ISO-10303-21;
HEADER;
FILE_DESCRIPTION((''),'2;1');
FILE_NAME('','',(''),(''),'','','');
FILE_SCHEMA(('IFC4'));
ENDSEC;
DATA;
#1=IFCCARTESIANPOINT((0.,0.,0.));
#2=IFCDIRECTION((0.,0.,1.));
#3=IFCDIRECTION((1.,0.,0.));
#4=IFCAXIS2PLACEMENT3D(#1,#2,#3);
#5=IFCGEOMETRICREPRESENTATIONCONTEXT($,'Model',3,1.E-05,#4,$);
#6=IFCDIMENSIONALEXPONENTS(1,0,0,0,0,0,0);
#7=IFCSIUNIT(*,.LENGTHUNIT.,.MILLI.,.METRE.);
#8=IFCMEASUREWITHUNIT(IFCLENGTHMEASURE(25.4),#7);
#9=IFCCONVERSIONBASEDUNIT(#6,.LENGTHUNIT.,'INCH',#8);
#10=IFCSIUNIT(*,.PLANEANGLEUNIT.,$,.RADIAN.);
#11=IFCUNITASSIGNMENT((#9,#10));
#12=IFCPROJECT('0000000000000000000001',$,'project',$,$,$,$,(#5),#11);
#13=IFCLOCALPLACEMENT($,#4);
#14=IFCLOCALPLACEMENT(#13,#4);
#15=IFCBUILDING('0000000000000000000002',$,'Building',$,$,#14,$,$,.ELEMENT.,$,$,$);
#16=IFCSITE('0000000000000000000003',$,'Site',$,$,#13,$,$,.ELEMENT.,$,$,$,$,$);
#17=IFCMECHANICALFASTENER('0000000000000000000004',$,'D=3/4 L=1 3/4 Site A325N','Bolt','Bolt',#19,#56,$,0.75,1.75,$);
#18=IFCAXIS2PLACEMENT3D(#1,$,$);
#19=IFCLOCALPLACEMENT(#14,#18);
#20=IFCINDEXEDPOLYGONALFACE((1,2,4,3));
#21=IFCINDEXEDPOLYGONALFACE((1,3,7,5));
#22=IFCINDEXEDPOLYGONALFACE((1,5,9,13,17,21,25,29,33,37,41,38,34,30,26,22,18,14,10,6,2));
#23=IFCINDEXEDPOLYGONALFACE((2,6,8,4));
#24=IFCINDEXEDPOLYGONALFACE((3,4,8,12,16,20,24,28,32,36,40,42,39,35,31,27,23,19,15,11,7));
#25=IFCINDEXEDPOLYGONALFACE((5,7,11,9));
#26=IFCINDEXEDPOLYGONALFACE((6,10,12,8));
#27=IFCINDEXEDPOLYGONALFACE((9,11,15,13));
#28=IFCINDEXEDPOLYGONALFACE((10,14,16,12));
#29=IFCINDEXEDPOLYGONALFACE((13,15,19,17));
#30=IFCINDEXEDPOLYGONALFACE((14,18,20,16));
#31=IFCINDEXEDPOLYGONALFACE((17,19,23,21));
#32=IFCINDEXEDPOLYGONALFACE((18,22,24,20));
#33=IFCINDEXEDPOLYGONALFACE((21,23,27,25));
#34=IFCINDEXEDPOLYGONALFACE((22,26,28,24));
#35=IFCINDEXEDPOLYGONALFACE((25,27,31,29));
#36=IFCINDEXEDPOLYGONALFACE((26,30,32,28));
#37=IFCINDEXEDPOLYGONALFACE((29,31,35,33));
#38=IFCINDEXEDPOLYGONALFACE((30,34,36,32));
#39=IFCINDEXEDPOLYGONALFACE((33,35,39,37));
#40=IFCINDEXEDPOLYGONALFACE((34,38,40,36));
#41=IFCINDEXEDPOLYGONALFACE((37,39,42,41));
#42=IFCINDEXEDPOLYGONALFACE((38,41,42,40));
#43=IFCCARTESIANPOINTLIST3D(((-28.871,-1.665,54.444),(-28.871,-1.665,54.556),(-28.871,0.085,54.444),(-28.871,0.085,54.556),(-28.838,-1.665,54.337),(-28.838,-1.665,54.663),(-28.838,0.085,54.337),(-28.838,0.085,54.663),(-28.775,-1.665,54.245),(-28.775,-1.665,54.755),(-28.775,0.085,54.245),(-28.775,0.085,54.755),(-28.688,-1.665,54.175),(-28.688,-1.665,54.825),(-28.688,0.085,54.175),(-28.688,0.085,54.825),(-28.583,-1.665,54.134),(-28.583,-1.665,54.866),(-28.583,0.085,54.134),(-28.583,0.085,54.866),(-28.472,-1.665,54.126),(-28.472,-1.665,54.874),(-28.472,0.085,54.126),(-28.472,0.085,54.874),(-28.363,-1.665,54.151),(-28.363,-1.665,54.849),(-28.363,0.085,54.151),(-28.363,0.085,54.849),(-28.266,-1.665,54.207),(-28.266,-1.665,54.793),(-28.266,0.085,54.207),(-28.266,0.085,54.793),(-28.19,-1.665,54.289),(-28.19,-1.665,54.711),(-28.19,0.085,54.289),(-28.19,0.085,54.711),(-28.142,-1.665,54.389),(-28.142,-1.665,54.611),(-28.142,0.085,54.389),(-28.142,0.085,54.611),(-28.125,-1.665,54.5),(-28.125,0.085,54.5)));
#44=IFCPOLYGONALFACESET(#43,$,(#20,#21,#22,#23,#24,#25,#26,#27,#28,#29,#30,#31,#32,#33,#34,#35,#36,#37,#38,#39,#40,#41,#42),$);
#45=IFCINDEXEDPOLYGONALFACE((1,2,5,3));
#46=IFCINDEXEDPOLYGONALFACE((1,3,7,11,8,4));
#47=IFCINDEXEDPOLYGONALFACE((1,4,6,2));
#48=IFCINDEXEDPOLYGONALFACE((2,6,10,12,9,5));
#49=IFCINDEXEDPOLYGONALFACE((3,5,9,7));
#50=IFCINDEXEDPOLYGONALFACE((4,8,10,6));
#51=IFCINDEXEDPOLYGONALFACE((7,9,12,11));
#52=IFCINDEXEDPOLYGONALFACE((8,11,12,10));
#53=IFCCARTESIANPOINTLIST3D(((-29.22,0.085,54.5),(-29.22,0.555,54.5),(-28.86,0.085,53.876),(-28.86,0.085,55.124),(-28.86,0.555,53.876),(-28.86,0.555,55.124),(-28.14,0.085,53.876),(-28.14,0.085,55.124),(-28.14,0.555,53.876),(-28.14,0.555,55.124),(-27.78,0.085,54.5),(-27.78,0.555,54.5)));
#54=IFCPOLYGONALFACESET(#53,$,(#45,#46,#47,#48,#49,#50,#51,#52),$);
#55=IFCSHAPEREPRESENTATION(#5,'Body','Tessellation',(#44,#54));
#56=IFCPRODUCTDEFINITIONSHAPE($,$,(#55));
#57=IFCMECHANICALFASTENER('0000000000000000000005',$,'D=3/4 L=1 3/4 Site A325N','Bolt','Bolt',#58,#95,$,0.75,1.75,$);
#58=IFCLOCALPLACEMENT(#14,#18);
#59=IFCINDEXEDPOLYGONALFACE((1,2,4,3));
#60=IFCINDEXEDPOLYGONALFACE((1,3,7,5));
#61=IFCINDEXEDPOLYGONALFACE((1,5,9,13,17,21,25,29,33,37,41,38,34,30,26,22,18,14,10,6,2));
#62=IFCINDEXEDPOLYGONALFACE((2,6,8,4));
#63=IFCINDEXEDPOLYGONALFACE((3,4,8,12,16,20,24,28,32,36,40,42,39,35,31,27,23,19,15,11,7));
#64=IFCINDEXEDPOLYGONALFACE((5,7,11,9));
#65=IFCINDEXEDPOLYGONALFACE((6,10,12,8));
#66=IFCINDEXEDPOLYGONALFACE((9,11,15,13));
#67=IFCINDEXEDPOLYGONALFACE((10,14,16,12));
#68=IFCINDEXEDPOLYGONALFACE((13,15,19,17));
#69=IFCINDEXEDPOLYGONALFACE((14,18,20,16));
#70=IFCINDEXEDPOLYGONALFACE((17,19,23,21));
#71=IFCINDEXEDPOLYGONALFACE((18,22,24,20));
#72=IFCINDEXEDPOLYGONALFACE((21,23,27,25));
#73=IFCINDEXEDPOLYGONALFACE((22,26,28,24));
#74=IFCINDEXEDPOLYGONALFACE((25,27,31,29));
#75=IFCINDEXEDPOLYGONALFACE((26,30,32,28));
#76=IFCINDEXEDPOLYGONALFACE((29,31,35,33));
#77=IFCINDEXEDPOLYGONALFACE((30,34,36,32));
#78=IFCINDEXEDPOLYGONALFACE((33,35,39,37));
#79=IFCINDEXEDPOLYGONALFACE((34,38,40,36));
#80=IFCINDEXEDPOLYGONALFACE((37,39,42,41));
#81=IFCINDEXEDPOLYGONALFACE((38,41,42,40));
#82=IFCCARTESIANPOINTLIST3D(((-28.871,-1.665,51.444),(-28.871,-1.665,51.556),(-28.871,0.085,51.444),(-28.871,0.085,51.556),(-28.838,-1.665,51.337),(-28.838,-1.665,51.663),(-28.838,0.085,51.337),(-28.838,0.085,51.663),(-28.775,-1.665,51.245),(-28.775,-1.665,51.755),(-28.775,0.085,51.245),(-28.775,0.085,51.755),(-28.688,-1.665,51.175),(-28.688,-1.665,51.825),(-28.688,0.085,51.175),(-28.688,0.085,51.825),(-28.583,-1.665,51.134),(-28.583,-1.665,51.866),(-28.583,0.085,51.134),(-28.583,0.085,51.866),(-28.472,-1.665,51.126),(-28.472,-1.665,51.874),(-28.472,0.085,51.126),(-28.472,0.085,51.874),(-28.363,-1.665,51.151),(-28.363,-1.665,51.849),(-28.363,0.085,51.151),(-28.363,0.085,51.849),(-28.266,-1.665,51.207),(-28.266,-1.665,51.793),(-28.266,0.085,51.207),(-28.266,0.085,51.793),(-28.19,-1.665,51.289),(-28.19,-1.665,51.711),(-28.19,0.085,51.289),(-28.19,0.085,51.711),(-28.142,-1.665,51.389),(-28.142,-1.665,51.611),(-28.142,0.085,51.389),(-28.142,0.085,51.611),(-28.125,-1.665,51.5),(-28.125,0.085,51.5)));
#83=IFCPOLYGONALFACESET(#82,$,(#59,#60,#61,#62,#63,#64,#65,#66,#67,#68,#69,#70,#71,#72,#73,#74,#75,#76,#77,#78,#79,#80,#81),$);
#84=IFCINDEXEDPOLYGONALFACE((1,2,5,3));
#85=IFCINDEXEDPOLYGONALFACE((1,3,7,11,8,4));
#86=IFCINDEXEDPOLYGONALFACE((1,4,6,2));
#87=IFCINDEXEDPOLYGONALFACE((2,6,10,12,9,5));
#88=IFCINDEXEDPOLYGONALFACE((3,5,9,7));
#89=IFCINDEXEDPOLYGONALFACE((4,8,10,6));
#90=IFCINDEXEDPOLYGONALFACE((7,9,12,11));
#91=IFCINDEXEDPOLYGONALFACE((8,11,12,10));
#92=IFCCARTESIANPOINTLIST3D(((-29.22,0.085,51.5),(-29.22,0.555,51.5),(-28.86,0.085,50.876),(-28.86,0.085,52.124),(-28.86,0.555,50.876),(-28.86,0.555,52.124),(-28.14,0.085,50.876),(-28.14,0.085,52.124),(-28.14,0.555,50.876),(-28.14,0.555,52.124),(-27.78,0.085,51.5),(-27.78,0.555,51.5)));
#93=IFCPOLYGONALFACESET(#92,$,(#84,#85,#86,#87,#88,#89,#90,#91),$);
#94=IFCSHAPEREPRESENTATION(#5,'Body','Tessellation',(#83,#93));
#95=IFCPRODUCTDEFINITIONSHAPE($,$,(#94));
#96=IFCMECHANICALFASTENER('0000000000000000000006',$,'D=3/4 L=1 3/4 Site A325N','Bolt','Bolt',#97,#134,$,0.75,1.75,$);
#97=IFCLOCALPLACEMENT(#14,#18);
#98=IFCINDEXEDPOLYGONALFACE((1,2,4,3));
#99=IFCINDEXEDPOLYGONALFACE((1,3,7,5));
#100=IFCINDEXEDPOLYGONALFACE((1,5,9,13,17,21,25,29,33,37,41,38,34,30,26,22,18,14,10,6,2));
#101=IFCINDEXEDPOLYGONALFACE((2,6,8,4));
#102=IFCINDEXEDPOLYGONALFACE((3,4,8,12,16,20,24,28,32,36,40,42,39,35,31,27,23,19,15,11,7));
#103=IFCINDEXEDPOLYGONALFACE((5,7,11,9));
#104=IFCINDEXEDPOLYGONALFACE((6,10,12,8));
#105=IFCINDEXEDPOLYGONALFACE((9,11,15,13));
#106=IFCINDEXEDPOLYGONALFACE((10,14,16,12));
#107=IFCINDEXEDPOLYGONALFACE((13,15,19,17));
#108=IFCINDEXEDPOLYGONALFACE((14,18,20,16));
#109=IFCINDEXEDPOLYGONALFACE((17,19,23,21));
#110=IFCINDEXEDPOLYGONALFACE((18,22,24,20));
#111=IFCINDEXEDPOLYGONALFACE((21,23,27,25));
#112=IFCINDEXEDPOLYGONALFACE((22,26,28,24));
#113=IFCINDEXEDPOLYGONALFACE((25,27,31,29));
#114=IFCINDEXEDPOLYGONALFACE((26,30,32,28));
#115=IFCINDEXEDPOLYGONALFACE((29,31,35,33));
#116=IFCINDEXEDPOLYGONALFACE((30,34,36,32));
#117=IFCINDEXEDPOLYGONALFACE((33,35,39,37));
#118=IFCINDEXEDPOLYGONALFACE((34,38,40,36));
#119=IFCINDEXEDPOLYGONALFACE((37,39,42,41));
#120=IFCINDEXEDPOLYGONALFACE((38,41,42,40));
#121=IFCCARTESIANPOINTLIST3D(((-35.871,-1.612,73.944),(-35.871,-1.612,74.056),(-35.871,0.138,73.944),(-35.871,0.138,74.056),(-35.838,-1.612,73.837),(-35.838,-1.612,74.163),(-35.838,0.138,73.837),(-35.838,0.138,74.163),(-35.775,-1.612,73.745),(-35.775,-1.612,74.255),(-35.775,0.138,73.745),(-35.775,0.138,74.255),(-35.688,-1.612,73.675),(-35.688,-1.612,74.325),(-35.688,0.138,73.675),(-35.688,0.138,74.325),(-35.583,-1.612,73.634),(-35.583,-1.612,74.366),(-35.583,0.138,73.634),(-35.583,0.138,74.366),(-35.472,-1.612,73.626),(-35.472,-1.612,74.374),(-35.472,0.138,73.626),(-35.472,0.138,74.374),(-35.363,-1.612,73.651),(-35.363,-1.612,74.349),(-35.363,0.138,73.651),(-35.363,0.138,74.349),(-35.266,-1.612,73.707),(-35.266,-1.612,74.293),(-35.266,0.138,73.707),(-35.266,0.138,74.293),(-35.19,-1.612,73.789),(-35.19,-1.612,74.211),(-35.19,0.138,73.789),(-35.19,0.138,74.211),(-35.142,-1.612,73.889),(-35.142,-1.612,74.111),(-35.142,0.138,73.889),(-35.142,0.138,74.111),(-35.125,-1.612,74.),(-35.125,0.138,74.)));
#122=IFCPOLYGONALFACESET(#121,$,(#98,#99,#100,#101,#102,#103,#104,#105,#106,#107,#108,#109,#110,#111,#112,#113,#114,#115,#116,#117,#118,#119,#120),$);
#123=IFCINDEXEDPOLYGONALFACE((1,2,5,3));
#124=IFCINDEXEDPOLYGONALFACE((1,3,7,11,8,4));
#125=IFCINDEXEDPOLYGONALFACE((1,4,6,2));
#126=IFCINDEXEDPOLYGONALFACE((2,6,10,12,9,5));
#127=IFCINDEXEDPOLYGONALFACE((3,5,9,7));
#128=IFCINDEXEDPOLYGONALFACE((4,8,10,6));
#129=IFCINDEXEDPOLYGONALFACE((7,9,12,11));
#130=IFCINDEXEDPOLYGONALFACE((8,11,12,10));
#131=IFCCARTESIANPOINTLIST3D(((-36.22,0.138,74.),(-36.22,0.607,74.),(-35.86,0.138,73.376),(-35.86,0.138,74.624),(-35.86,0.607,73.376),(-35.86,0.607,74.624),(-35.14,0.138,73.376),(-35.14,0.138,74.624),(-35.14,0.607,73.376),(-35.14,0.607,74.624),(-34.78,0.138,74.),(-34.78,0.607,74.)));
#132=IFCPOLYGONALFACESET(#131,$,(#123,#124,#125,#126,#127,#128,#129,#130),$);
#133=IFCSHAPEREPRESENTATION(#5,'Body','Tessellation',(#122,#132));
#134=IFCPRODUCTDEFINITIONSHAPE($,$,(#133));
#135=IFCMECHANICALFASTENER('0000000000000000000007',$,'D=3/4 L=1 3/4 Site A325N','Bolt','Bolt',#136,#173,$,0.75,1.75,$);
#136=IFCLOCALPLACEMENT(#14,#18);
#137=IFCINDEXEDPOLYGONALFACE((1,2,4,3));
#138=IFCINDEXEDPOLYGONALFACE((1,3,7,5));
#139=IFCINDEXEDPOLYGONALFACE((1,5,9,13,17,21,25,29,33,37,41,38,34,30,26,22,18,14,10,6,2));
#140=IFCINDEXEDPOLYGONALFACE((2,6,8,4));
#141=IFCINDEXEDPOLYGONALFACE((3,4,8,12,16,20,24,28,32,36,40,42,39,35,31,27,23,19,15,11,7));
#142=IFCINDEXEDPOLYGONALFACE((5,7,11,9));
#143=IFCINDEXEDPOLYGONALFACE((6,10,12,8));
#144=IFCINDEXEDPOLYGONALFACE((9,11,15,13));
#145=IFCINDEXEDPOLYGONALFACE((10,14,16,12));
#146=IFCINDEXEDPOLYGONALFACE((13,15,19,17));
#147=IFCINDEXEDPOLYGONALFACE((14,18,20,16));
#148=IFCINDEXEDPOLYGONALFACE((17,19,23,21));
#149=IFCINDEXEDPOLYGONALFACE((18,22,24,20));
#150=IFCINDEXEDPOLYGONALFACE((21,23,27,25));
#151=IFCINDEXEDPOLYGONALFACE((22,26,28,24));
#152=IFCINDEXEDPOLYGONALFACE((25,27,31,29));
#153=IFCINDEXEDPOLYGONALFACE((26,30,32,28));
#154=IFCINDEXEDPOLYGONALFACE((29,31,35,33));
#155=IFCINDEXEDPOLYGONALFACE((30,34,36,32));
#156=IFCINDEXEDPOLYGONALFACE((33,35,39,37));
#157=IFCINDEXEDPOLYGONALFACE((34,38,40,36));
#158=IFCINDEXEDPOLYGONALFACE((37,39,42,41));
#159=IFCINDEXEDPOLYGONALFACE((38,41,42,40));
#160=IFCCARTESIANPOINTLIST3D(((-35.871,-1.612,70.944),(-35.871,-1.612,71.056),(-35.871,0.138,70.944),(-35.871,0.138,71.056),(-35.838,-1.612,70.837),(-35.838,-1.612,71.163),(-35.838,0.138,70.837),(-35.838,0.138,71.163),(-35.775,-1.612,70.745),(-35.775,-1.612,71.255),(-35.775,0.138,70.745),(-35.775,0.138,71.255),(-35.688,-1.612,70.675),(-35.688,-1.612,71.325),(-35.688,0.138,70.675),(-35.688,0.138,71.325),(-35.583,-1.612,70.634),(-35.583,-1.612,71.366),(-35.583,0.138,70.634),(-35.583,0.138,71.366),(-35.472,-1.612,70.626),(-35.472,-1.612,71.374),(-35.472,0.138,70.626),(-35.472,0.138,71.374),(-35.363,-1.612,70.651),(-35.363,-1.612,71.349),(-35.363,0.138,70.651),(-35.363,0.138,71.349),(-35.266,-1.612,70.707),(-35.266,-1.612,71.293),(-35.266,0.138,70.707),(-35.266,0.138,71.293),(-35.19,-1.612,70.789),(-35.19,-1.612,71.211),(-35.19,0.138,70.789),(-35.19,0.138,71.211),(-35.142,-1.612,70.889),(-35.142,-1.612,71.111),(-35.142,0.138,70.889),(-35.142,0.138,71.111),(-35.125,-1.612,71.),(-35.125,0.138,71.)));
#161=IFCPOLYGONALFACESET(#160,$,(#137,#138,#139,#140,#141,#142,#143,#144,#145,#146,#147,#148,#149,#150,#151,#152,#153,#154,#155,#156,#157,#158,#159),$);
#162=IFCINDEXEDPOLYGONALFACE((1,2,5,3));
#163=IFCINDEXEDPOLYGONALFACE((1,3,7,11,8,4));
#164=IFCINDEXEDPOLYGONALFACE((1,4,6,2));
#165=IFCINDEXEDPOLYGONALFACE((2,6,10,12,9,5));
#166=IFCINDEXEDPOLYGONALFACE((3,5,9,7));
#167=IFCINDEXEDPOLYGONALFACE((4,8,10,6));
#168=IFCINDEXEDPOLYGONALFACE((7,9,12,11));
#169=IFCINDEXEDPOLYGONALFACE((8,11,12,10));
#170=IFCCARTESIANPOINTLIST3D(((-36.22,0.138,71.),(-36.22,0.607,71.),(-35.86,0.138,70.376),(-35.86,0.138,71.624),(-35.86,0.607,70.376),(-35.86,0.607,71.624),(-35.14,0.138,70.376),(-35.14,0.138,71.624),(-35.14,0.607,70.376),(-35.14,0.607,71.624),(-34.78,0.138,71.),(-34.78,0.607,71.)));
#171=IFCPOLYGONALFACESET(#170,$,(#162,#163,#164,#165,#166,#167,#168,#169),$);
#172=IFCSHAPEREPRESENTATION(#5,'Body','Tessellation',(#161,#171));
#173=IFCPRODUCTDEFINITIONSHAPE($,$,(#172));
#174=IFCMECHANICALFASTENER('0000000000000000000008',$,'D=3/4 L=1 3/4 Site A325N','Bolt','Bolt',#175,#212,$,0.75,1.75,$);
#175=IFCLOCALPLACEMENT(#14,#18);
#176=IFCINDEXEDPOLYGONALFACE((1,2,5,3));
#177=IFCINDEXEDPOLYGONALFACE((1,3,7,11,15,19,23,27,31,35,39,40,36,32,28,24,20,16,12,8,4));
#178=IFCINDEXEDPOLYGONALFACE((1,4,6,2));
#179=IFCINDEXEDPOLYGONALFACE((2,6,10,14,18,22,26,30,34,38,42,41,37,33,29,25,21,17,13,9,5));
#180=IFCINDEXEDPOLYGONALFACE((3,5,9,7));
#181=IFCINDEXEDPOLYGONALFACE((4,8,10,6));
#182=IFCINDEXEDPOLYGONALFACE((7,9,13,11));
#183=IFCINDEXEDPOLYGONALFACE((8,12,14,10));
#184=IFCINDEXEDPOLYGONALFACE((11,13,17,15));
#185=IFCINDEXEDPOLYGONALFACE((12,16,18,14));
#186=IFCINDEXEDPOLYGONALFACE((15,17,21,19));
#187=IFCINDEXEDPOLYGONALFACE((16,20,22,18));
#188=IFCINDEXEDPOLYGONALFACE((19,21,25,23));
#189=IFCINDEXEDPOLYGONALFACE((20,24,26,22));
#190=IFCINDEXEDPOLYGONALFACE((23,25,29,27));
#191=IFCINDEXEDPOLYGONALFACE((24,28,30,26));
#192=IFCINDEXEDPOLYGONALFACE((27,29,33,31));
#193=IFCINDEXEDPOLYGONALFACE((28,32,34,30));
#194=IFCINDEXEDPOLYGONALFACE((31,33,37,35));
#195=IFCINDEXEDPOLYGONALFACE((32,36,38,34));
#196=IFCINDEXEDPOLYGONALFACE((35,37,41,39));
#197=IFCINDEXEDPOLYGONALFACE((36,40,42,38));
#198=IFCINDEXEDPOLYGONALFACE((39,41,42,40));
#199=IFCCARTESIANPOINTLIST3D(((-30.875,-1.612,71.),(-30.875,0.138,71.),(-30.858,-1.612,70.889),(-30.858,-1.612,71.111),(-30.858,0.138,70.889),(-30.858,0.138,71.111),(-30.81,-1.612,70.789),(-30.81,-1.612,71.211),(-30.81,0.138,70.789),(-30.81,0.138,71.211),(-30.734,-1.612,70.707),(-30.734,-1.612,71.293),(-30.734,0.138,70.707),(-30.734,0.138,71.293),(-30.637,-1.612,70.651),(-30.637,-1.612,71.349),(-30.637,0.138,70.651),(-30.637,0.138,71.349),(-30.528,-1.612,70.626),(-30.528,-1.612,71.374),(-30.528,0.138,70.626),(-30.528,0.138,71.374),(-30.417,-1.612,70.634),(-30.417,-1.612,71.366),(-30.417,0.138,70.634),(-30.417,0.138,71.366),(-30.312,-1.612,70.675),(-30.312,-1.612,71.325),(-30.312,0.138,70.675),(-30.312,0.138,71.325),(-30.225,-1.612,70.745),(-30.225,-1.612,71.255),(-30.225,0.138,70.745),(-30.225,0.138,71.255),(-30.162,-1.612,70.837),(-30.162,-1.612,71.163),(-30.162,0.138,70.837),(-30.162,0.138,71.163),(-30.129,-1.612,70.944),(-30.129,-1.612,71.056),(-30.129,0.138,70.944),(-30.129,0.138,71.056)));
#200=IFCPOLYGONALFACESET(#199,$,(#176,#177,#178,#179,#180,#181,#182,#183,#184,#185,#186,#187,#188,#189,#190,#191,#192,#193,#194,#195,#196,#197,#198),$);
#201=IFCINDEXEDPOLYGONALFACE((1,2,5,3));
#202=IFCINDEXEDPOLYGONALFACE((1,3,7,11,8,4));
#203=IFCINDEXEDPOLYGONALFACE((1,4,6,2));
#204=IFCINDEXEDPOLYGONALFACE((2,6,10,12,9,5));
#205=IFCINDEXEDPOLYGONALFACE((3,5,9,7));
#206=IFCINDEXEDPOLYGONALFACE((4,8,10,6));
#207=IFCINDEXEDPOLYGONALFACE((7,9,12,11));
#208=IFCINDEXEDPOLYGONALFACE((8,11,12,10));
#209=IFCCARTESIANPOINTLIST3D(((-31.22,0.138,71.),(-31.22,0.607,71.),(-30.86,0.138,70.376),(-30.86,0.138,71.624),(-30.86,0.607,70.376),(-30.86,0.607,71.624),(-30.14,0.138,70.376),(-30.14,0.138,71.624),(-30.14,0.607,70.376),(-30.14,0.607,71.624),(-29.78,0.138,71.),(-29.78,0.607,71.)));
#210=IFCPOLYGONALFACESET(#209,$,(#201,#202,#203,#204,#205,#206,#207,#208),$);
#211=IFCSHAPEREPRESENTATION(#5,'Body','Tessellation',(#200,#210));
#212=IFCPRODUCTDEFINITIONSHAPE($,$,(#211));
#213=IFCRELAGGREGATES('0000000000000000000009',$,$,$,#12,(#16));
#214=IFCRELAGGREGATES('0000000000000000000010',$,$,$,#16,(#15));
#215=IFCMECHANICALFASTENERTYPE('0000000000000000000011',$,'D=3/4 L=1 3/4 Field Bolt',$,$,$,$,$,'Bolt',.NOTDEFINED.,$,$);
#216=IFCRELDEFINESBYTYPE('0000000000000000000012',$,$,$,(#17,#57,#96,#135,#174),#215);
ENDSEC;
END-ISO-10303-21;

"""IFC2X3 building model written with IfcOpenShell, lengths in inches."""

from ifc_helpers import new_model, entity, si_unit, converted_unit, frame, origin_with_axes, origin_2d_with_axis, place, context, project, spatial, polyline, circle, outline, extrude, source, transform, mapped, type_object, type_shapes, element, save


model = new_model("IFC2X3")

# Units and contexts
model_context = context("Model", 3, precision=1e-05, world=origin_with_axes())
ifc_project = project(units=[converted_unit("LENGTHUNIT", "INCH", entity("IfcLengthMeasure", 25.4), si_unit("LENGTHUNIT", "METRE", prefix="MILLI"), dimensions=[1, 0, 0, 0, 0, 0, 0]), si_unit("PLANEANGLEUNIT", "RADIAN")], contexts=[model_context])

# Site, building
site_placement = place(None, origin_with_axes())
site = spatial("IfcSite", under=ifc_project, at=site_placement, Name="Site", CompositionType="ELEMENT")
building_placement = place(site_placement, origin_with_axes())
building = spatial("IfcBuilding", under=site, at=building_placement, Name="Building", CompositionType="ELEMENT")

# Mechanical fasteners
mechanical_fastener_type_1 = type_object("IfcMechanicalFastenerType", Name="D=3/4 L=1 3/4 Field Bolt", ElementType="Bolt")
shared_shape_1 = source(origin_with_axes(), model_context, "Body", "SweptSolid", [
    extrude(circle(Radius=0.375, at=origin_2d_with_axis()), frame((0.0, 0.0, 0.0), z_axis=(1.0, 0.0, 0.0), x_axis=(0.0, 1.0, 0.0)), (0.0, 0.0, 1.0), 1.75),
    extrude(outline(polyline([(-0.72, 0.0), (-0.36, 0.624), (0.36, 0.624), (0.72, 0.0), (0.36, -0.624), (-0.36, -0.624), (-0.72, 0.0)])), frame((0.0, 0.0, 0.0), z_axis=(1.0, 0.0, 0.0), x_axis=(0.0, 1.0, 0.0)), (0.0, 0.0, -1.0), 0.47),
])
type_shapes(mechanical_fastener_type_1, [shared_shape_1])
placement_1 = place(building_placement, frame((-9.25, 0.0, 57.0), z_axis=(0.0, 0.0, 1.0), x_axis=(-1.0, 0.0, 0.0)))
placement_2 = place(placement_1, frame((19.25, -0.085, -2.5), z_axis=(0.0, 0.0, 1.0), x_axis=(0.0, 1.0, 0.0)))
for number, where, z_axis, x_axis, name in (
    (1, (0.0, 0.0, 0.0), (0.0, 0.0, 1.0), (1.0, 0.0, 0.0), "D=3/4 L=1 3/4 Site A325N"),
    (2, (0.0, 0.0, -3.0), (0.0, 0.0, 1.0), (1.0, 0.0, 0.0), "D=3/4 L=1 3/4 Site A325N"),
):
    element("IfcMechanicalFastener", number, at=place(placement_2, frame(where, z_axis=z_axis, x_axis=x_axis)), type_object=mechanical_fastener_type_1, Name=name, Description="Bolt", ObjectType="Bolt", NominalDiameter=0.75, NominalLength=1.75, context=model_context, shape_type="MappedRepresentation", body=[
        mapped(shared_shape_1, transform((0.0, 0.0, 0.0), scale=1.0)),
    ])
placement_3 = place(building_placement, frame((-33.0, 0.0, 77.0), z_axis=(0.0, 0.0, 1.0), x_axis=(0.0, -1.0, 0.0)))
placement_4 = place(placement_3, frame((-0.138, -2.5, -6.0), z_axis=(0.0, 0.0, 1.0), x_axis=(1.0, 0.0, 0.0)))
for number, where, z_axis, x_axis, name in (
    (3, (0.0, 0.0, 3.0), (0.0, 0.0, 1.0), (1.0, 0.0, 0.0), "D=3/4 L=1 3/4 Site A325N"),
    (4, (0.0, 0.0, 0.0), (0.0, 0.0, 1.0), (1.0, 0.0, 0.0), "D=3/4 L=1 3/4 Site A325N"),
):
    element("IfcMechanicalFastener", number, at=place(placement_4, frame(where, z_axis=z_axis, x_axis=x_axis)), type_object=mechanical_fastener_type_1, Name=name, Description="Bolt", ObjectType="Bolt", NominalDiameter=0.75, NominalLength=1.75, context=model_context, shape_type="MappedRepresentation", body=[
        mapped(shared_shape_1, transform((0.0, 0.0, 0.0), scale=1.0)),
    ])
placement_5 = place(placement_3, frame((-0.138, 2.5, -3.0), z_axis=(0.0, 0.0, -1.0), x_axis=(1.0, 0.0, 0.0)))
mechanical_fastener_1_placement = place(placement_5, frame((0.0, 0.0, 3.0), z_axis=(0.0, 0.0, 1.0), x_axis=(1.0, 0.0, 0.0)))
element("IfcMechanicalFastener", 5, at=mechanical_fastener_1_placement, type_object=mechanical_fastener_type_1, Name="D=3/4 L=1 3/4 Site A325N", Description="Bolt", ObjectType="Bolt", NominalDiameter=0.75, NominalLength=1.75, context=model_context, shape_type="MappedRepresentation", body=[
    mapped(shared_shape_1, transform((0.0, 0.0, 0.0), scale=1.0)),
])

save(model, "model.ifc")
